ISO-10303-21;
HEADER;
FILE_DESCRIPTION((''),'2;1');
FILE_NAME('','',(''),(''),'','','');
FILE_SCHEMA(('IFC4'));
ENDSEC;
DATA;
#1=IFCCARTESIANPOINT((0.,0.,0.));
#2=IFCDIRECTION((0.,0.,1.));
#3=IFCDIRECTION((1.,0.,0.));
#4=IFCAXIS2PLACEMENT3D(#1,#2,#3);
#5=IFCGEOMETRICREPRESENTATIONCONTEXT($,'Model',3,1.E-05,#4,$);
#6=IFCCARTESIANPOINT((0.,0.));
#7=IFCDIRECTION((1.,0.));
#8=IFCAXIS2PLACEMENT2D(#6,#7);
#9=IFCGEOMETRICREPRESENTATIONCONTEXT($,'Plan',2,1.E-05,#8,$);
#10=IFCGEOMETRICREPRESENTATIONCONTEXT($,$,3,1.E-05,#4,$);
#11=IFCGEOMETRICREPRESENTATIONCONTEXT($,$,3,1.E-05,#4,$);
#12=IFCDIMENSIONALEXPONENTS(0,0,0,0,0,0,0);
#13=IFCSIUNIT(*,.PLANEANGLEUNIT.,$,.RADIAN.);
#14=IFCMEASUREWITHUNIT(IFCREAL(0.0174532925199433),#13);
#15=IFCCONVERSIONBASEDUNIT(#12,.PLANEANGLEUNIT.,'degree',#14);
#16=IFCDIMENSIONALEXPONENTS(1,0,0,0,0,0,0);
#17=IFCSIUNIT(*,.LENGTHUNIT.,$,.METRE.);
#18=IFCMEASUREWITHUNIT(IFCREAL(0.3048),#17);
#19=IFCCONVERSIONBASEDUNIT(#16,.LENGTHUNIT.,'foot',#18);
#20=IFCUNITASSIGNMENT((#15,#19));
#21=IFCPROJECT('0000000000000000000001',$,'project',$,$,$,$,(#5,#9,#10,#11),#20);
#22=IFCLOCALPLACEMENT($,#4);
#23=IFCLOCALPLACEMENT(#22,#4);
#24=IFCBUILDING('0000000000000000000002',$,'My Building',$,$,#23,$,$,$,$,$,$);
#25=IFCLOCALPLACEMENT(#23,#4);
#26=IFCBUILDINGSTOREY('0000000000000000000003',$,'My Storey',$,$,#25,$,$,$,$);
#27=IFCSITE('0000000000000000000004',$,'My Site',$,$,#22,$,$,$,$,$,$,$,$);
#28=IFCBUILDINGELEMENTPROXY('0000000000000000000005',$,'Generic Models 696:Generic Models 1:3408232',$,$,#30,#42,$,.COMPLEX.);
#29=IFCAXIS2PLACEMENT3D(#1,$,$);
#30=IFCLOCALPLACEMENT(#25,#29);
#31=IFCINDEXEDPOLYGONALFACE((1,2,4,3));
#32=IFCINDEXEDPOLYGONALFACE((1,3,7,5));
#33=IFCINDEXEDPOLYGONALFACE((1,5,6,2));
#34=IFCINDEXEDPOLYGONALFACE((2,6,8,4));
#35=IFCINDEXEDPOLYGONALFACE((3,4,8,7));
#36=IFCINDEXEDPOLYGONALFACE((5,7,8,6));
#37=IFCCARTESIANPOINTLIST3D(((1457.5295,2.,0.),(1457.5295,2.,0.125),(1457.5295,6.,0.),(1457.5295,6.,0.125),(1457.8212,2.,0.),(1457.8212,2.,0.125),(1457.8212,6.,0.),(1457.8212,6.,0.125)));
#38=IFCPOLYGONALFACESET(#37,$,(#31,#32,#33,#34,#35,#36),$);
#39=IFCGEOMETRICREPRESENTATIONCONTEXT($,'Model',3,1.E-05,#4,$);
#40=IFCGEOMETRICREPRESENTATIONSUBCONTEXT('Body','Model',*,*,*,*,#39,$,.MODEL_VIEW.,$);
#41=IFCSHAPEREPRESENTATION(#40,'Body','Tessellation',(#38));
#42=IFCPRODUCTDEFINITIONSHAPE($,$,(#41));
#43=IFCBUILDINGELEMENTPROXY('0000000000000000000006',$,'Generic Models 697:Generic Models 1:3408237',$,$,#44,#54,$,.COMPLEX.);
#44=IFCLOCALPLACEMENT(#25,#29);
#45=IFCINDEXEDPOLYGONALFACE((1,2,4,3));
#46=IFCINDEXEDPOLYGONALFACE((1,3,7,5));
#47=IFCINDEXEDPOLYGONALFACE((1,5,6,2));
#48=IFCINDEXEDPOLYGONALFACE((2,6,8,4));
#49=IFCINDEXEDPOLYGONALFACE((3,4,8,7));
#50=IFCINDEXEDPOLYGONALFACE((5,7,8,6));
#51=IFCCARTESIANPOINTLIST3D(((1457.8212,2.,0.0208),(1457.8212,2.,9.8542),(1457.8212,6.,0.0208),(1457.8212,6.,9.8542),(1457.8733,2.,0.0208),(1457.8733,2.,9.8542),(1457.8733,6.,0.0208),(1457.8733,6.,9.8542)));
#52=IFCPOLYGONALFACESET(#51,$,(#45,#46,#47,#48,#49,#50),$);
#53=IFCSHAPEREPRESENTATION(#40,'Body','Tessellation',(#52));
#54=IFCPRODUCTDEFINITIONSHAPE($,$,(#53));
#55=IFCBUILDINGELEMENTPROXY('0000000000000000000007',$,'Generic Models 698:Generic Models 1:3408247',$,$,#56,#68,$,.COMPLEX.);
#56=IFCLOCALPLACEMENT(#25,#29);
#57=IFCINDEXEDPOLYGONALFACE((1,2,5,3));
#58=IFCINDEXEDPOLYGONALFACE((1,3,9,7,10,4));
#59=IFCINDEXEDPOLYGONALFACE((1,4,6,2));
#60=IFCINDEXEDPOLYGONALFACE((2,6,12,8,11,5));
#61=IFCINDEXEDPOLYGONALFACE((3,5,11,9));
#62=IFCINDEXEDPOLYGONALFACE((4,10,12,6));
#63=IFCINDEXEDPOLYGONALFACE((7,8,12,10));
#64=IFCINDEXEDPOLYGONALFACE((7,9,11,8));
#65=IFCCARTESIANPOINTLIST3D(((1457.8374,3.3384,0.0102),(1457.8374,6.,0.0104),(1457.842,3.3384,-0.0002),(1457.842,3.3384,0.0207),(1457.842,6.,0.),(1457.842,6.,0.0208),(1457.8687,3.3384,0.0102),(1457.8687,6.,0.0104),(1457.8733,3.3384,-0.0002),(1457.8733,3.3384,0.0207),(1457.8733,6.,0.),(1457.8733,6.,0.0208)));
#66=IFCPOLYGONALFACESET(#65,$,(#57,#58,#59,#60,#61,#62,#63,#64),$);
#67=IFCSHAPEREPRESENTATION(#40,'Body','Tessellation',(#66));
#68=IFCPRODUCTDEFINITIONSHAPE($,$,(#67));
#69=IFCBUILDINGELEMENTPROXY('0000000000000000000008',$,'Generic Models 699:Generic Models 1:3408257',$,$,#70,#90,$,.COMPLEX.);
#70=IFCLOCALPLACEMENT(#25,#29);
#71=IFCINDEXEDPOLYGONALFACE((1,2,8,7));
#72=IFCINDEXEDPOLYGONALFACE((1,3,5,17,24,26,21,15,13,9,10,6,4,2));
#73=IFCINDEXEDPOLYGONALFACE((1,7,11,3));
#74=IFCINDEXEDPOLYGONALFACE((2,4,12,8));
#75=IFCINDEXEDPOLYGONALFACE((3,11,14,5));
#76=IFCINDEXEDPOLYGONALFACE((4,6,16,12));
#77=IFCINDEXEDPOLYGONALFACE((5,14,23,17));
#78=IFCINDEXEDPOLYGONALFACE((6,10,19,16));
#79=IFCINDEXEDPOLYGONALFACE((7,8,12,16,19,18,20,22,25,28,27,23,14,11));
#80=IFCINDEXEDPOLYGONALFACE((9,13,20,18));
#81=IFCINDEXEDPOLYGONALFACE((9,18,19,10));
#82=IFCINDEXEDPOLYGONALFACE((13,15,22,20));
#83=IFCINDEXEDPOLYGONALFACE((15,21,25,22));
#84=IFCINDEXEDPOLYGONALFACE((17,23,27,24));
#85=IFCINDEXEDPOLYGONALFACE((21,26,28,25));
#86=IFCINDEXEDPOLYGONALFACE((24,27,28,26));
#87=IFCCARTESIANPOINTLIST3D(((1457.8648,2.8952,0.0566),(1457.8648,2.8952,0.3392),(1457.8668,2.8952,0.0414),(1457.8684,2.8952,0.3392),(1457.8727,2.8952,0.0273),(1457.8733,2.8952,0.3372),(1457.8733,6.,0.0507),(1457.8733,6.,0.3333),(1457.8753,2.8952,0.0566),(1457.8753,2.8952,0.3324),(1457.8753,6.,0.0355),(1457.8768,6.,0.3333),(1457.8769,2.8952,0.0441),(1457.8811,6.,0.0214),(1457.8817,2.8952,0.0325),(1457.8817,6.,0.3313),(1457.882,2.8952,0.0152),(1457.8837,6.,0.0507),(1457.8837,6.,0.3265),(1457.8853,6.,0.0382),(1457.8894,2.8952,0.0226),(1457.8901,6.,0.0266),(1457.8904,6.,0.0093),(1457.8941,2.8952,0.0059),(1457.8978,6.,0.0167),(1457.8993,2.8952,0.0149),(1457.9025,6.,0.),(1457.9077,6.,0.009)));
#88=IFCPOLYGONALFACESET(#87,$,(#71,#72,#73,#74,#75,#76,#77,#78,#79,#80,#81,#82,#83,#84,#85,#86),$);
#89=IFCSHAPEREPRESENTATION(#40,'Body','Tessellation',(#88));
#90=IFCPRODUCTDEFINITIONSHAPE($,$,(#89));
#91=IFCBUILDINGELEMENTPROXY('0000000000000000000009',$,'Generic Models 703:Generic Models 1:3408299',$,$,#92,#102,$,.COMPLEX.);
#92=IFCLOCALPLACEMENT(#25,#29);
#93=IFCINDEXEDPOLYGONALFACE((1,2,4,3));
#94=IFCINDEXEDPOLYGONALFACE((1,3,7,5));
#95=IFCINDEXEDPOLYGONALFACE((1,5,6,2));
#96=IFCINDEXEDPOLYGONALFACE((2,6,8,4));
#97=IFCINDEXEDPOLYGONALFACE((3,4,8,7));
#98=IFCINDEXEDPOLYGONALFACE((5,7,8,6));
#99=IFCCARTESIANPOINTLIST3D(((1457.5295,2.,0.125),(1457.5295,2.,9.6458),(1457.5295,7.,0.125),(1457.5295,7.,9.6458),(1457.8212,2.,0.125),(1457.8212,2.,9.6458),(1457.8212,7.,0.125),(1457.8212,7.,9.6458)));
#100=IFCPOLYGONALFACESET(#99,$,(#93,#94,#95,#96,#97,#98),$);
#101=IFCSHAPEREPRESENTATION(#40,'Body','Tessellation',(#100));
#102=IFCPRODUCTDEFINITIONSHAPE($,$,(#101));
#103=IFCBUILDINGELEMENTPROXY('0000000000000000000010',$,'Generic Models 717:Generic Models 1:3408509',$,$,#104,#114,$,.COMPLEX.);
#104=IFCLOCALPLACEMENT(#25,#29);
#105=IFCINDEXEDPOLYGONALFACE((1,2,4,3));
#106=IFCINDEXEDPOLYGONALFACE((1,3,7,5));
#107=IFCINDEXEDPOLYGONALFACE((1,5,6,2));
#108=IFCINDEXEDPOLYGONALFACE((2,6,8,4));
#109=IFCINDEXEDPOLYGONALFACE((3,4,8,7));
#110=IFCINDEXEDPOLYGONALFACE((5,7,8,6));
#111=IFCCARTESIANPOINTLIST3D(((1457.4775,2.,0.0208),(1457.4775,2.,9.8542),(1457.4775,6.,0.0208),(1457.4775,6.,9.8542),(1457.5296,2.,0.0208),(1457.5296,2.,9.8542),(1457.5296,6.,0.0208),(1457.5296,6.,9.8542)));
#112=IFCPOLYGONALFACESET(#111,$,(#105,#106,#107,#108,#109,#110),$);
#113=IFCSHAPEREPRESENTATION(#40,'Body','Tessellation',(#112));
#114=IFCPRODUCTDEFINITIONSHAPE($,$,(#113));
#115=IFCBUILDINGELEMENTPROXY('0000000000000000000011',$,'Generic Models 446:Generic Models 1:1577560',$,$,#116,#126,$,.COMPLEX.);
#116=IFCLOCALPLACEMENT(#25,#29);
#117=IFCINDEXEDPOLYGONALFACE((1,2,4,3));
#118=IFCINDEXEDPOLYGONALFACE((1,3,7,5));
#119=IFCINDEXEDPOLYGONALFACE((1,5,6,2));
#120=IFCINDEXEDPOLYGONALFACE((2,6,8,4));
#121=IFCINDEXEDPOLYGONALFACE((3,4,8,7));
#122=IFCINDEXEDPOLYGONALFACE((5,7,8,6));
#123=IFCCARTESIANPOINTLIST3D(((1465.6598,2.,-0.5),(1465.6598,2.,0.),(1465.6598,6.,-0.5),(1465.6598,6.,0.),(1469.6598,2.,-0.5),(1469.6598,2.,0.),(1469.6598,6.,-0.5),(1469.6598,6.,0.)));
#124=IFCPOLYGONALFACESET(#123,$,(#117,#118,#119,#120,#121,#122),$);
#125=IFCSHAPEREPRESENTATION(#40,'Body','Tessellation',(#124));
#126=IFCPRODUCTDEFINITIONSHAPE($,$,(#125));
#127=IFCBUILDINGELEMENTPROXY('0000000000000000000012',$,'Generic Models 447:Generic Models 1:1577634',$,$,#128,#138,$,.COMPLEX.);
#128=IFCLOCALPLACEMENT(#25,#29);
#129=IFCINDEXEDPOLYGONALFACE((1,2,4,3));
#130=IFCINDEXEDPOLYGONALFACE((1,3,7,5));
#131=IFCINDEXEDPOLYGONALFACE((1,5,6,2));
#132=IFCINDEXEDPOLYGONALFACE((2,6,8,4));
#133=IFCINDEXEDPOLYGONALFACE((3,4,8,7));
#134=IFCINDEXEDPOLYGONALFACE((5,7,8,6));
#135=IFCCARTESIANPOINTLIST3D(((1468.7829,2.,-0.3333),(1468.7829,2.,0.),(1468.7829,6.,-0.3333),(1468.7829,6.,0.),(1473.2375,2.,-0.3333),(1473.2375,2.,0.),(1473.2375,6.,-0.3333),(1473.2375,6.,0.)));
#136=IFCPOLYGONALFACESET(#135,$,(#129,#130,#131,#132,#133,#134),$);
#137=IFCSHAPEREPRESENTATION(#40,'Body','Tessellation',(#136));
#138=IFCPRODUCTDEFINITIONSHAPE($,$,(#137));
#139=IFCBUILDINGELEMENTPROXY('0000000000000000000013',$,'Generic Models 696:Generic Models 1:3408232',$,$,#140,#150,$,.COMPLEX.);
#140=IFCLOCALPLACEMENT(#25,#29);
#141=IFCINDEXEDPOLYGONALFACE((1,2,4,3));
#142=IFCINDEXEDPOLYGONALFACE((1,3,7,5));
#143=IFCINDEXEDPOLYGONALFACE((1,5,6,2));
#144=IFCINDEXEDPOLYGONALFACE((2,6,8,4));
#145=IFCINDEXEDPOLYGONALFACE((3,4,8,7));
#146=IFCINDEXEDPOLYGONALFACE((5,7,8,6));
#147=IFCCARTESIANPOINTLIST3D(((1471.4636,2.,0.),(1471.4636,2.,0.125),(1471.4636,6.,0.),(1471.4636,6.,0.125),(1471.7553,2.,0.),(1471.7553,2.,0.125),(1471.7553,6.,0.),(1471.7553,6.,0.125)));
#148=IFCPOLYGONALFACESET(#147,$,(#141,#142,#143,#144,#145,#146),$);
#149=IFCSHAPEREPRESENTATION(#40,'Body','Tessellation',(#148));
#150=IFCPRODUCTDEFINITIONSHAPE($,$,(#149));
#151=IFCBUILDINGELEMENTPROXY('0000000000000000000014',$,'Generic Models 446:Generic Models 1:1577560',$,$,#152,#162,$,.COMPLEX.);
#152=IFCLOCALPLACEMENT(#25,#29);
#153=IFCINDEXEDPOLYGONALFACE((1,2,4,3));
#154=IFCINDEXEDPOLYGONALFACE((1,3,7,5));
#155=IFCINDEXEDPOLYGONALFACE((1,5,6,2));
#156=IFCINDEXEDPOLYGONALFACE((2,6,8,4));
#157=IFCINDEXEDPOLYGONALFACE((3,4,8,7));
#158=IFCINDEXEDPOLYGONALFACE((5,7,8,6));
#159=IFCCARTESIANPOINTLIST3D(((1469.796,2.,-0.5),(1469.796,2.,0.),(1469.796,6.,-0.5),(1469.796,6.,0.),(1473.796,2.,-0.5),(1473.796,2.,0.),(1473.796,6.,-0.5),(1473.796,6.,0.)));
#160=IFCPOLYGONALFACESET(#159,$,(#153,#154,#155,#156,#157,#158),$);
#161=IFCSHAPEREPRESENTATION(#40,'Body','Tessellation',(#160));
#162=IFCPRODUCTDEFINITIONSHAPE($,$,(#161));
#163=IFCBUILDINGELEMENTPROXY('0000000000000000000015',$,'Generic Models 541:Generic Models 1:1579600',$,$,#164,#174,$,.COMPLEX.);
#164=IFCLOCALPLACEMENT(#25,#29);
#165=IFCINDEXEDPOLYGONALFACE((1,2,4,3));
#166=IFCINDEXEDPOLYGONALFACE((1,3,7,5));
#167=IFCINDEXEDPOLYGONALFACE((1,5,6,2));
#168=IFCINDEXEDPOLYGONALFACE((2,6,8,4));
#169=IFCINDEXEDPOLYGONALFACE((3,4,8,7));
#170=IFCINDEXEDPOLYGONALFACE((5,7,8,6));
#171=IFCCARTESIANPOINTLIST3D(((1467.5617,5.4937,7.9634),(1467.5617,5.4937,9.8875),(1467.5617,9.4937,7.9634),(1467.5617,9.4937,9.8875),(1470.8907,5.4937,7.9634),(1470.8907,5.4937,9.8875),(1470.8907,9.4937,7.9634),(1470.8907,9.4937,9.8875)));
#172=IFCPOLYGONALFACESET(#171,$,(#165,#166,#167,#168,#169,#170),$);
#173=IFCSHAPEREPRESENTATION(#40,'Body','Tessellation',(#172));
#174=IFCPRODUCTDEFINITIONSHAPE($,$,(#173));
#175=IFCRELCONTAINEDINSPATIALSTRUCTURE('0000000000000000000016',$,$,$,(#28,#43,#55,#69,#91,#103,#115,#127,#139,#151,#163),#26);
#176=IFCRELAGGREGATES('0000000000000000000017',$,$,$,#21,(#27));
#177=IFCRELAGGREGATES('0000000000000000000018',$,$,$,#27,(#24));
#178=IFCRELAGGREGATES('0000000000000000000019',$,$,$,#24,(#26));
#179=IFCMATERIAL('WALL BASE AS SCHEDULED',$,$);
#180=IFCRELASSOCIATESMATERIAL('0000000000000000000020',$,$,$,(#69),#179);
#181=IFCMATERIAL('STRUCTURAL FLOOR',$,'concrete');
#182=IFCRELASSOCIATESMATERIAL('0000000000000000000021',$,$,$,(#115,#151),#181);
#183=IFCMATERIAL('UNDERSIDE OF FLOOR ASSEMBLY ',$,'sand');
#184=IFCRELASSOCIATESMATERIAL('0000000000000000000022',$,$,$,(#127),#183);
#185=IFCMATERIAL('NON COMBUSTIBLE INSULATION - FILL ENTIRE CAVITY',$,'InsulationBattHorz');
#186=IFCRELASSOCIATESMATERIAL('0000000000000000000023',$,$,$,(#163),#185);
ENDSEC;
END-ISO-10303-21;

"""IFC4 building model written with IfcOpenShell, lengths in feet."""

from ifc_helpers import new_model, entity, si_unit, converted_unit, frame, origin_with_axes, origin_2d_with_axis, place, context, subcontext, project, spatial, polyline, line, indexed_curve, outline, extrude, material, element, save


model = new_model("IFC4")

# Units and contexts
model_context_1 = context("Model", 3, precision=1e-05, world=origin_with_axes())
plan_context = context("Plan", 2, precision=1e-05, world=origin_2d_with_axis())
model_context_2 = context("Model", 3, precision=1e-05, world=origin_with_axes())
context_of_model_1 = context(None, 3, precision=1e-05, world=origin_with_axes())
context_of_model_2 = context(None, 3, precision=1e-05, world=origin_with_axes())
body_context = subcontext(model_context_2, "Body", "Model", "MODEL_VIEW")
ifc_project = project(units=[converted_unit("PLANEANGLEUNIT", "degree", entity("IfcReal", 0.0174532925199433), si_unit("PLANEANGLEUNIT", "RADIAN"), dimensions=[0, 0, 0, 0, 0, 0, 0]), converted_unit("LENGTHUNIT", "foot", entity("IfcReal", 0.3048), si_unit("LENGTHUNIT", "METRE"), dimensions=[1, 0, 0, 0, 0, 0, 0])], contexts=[model_context_1, plan_context, context_of_model_1, context_of_model_2])

# Site, building, storey
site_placement = place(None, origin_with_axes())
site = spatial("IfcSite", under=ifc_project, at=site_placement, Name="My Site")
building_placement = place(site_placement, origin_with_axes())
building = spatial("IfcBuilding", under=site, at=building_placement, Name="My Building")
storey_placement = place(building_placement, origin_with_axes())
storey = spatial("IfcBuildingStorey", under=building, at=storey_placement, Name="My Storey")

# Building element proxies
proxy_1_placement = place(storey_placement, frame((1457.5295, 6.0, 0.0), z_axis=(0.0, -1.0, 0.0), x_axis=(0.0, 0.0, 1.0)))
element("IfcBuildingElementProxy", 1, at=proxy_1_placement, inside=storey, Name="Generic Models 696:Generic Models 1:3408232", PredefinedType="COMPLEX", context=body_context, shape_type="SweptSolid", body=[
    extrude(outline(polyline([(-0.0625, -0.1458), (0.0625, -0.1458), (0.0625, 0.1458), (-0.0625, 0.1458), (-0.0625, -0.1458)])), frame((0.0625, -0.1458, 0.0), z_axis=(0.0, 0.0, -1.0), x_axis=(1.0, 0.0, 0.0)), (0.0, 0.0, -1.0), 4.0),
])
proxy_2_placement = place(storey_placement, frame((1457.8212, 6.0, 0.0208), z_axis=(0.0, -1.0, 0.0), x_axis=(0.0, 0.0, 1.0)))
element("IfcBuildingElementProxy", 2, at=proxy_2_placement, inside=storey, Name="Generic Models 697:Generic Models 1:3408237", PredefinedType="COMPLEX", context=body_context, shape_type="SweptSolid", body=[
    extrude(outline(polyline([(-4.9167, -0.026), (4.9167, -0.026), (4.9167, 0.026), (-4.9167, 0.026), (-4.9167, -0.026)])), frame((4.9167, -0.026, 0.0), z_axis=(0.0, 0.0, -1.0), x_axis=(1.0, 0.0, 0.0)), (0.0, 0.0, -1.0), 4.0),
])
proxy_3_placement = place(storey_placement, frame((1457.8375, 6.0, 0.0), z_axis=(0.0, -1.0, 0.0), x_axis=(0.0, 0.0, 1.0)))
element("IfcBuildingElementProxy", 3, at=proxy_3_placement, inside=storey, Name="Generic Models 698:Generic Models 1:3408247", PredefinedType="COMPLEX", context=body_context, shape_type="SweptSolid", body=[
    extrude(outline(polyline([(0.0201, 0.0), (0.0107, 0.0065), (0.0093, 0.0178), (-0.0175, 0.0016), (-0.016, -0.0097), (-0.0066, -0.0162), (0.0201, 0.0)])), frame((0.0104, -0.0186, 0.0), z_axis=(0.0, 0.0, -1.0), x_axis=(0.51911, -0.854707, 0.0)), (-0.000034, 0.000057, -1.0), 2.6616),
])
ifc_material_1 = material(Name="WALL BASE AS SCHEDULED")
proxy_4_placement = place(storey_placement, frame((1457.8733, 6.0, 0.0), z_axis=(0.0, -1.0, 0.0), x_axis=(0.0, 0.0, 1.0)))
element("IfcBuildingElementProxy", 4, at=proxy_4_placement, inside=storey, material=ifc_material_1, Name="Generic Models 699:Generic Models 1:3408257", PredefinedType="COMPLEX", context=body_context, shape_type="SweptSolid", body=[
    extrude(outline(polyline([(0.2206, 0.0), (0.2204, 0.0036), (0.2182, 0.0083), (0.2132, 0.01), (-0.0621, -0.0058), (-0.0747, -0.0049), (-0.0865, -0.0007), (-0.0969, 0.0063), (-0.1051, 0.0158), (-0.1138, 0.0101), (-0.1038, -0.0014), (-0.0912, -0.01), (-0.0768, -0.0151), (-0.0615, -0.0162), (0.2206, 0.0)])), frame((0.113, -0.0126, 0.0), z_axis=(0.0, 0.0, -1.0), x_axis=(0.998358, 0.057286, 0.0)), (0.002054, -0.002598, -0.999995), 3.1048),
])
proxy_5_placement = place(storey_placement, frame((1457.5295, 6.0, 0.125), z_axis=(0.0, -1.0, 0.0), x_axis=(0.0, 0.0, 1.0)))
element("IfcBuildingElementProxy", 5, at=proxy_5_placement, inside=storey, Name="Generic Models 703:Generic Models 1:3408299", PredefinedType="COMPLEX", context=body_context, shape_type="SweptSolid", body=[
    extrude(outline(polyline([(-4.7604, -0.1458), (4.7604, -0.1458), (4.7604, 0.1458), (-4.7604, 0.1458), (-4.7604, -0.1458)])), frame((4.7604, -0.1458, -1.0), z_axis=(0.0, 0.0, -1.0), x_axis=(1.0, 0.0, 0.0)), (0.0, 0.0, -1.0), 5.0),
])
proxy_6_placement = place(storey_placement, frame((1457.4775, 6.0, 0.0208), z_axis=(0.0, -1.0, 0.0), x_axis=(0.0, 0.0, 1.0)))
element("IfcBuildingElementProxy", 6, at=proxy_6_placement, inside=storey, Name="Generic Models 717:Generic Models 1:3408509", PredefinedType="COMPLEX", context=body_context, shape_type="SweptSolid", body=[
    extrude(outline(polyline([(-0.026, -4.9167), (0.026, -4.9167), (0.026, 4.9167), (-0.026, 4.9167), (-0.026, -4.9167)])), frame((4.9167, -0.026, 0.0), z_axis=(0.0, 0.0, -1.0), x_axis=(0.0, -1.0, 0.0)), (0.0, 0.0, -1.0), 4.0),
])
ifc_material_2 = material(Name="STRUCTURAL FLOOR", Category="concrete")
proxy_7_placement = place(storey_placement, frame((1465.6598, 6.0, -0.5), z_axis=(0.0, -1.0, 0.0), x_axis=(0.0, 0.0, 1.0)))
element("IfcBuildingElementProxy", 7, at=proxy_7_placement, inside=storey, material=ifc_material_2, Name="Generic Models 446:Generic Models 1:1577560", PredefinedType="COMPLEX", context=body_context, shape_type="SweptSolid", body=[
    extrude(outline(polyline([(-2.0, -0.25), (2.0, -0.25), (2.0, 0.25), (-2.0, 0.25), (-2.0, -0.25)])), frame((0.25, -2.0, 0.0), z_axis=(0.0, 0.0, -1.0), x_axis=(0.0, 1.0, 0.0)), (0.0, 0.0, -1.0), 4.0),
])
ifc_material_3 = material(Name="UNDERSIDE OF FLOOR ASSEMBLY ", Category="sand")
proxy_8_placement = place(storey_placement, frame((1468.7829, 6.0, -0.3333), z_axis=(0.0, -1.0, 0.0), x_axis=(0.0, 0.0, 1.0)))
element("IfcBuildingElementProxy", 8, at=proxy_8_placement, inside=storey, material=ifc_material_3, Name="Generic Models 447:Generic Models 1:1577634", PredefinedType="COMPLEX", context=body_context, shape_type="SweptSolid", body=[
    extrude(outline(indexed_curve([(-2.4546, -0.1667), (2.0, -0.1667), (2.0, 0.1667), (-2.4546, 0.1667)], segments=[line(3, 2), line(2, 1), line(1, 4), line(4, 3)], self_intersect=False)), frame((0.1667, -2.0, 0.0), z_axis=(0.0, 0.0, -1.0), x_axis=(0.0, 1.0, 0.0)), (0.0, 0.0, -1.0), 4.0),
])
proxy_9_placement = place(storey_placement, frame((1471.4636, 6.0, 0.0), z_axis=(0.0, -1.0, 0.0), x_axis=(0.0, 0.0, 1.0)))
element("IfcBuildingElementProxy", 9, at=proxy_9_placement, inside=storey, Name="Generic Models 696:Generic Models 1:3408232", PredefinedType="COMPLEX", context=body_context, shape_type="SweptSolid", body=[
    extrude(outline(polyline([(-0.0625, -0.1458), (0.0625, -0.1458), (0.0625, 0.1458), (-0.0625, 0.1458), (-0.0625, -0.1458)])), frame((0.0625, -0.1458, 0.0), z_axis=(0.0, 0.0, -1.0), x_axis=(1.0, 0.0, 0.0)), (0.0, 0.0, -1.0), 4.0),
])
proxy_10_placement = place(storey_placement, frame((1469.796, 6.0, -0.5), z_axis=(0.0, -1.0, 0.0), x_axis=(0.0, 0.0, 1.0)))
element("IfcBuildingElementProxy", 10, at=proxy_10_placement, inside=storey, material=ifc_material_2, Name="Generic Models 446:Generic Models 1:1577560", PredefinedType="COMPLEX", context=body_context, shape_type="SweptSolid", body=[
    extrude(outline(polyline([(-2.0, -0.25), (2.0, -0.25), (2.0, 0.25), (-2.0, 0.25), (-2.0, -0.25)])), frame((0.25, -2.0, 0.0), z_axis=(0.0, 0.0, -1.0), x_axis=(0.0, 1.0, 0.0)), (0.0, 0.0, -1.0), 4.0),
])
ifc_material_4 = material(Name="NON COMBUSTIBLE INSULATION - FILL ENTIRE CAVITY", Category="InsulationBattHorz")
proxy_11_placement = place(storey_placement, frame((1470.2593, 9.4937, -0.055), z_axis=(0.0, -1.0, 0.0), x_axis=(0.0, 0.0, 1.0)))
element("IfcBuildingElementProxy", 11, at=proxy_11_placement, inside=storey, material=ifc_material_4, Name="Generic Models 541:Generic Models 1:1579600", PredefinedType="COMPLEX", context=body_context, shape_type="SweptSolid", body=[
    extrude(outline(polyline([(-0.9621, -1.6645), (0.9621, -1.6645), (0.9621, 1.6645), (-0.9621, 1.6645), (-0.9621, -1.6645)])), frame((8.9804, 1.0331, 0.0), z_axis=(0.0, 0.0, -1.0), x_axis=(-1.0, -0.000001, 0.0)), (0.0, 0.0, -1.0), 4.0),
])

save(model, "model.ifc")
